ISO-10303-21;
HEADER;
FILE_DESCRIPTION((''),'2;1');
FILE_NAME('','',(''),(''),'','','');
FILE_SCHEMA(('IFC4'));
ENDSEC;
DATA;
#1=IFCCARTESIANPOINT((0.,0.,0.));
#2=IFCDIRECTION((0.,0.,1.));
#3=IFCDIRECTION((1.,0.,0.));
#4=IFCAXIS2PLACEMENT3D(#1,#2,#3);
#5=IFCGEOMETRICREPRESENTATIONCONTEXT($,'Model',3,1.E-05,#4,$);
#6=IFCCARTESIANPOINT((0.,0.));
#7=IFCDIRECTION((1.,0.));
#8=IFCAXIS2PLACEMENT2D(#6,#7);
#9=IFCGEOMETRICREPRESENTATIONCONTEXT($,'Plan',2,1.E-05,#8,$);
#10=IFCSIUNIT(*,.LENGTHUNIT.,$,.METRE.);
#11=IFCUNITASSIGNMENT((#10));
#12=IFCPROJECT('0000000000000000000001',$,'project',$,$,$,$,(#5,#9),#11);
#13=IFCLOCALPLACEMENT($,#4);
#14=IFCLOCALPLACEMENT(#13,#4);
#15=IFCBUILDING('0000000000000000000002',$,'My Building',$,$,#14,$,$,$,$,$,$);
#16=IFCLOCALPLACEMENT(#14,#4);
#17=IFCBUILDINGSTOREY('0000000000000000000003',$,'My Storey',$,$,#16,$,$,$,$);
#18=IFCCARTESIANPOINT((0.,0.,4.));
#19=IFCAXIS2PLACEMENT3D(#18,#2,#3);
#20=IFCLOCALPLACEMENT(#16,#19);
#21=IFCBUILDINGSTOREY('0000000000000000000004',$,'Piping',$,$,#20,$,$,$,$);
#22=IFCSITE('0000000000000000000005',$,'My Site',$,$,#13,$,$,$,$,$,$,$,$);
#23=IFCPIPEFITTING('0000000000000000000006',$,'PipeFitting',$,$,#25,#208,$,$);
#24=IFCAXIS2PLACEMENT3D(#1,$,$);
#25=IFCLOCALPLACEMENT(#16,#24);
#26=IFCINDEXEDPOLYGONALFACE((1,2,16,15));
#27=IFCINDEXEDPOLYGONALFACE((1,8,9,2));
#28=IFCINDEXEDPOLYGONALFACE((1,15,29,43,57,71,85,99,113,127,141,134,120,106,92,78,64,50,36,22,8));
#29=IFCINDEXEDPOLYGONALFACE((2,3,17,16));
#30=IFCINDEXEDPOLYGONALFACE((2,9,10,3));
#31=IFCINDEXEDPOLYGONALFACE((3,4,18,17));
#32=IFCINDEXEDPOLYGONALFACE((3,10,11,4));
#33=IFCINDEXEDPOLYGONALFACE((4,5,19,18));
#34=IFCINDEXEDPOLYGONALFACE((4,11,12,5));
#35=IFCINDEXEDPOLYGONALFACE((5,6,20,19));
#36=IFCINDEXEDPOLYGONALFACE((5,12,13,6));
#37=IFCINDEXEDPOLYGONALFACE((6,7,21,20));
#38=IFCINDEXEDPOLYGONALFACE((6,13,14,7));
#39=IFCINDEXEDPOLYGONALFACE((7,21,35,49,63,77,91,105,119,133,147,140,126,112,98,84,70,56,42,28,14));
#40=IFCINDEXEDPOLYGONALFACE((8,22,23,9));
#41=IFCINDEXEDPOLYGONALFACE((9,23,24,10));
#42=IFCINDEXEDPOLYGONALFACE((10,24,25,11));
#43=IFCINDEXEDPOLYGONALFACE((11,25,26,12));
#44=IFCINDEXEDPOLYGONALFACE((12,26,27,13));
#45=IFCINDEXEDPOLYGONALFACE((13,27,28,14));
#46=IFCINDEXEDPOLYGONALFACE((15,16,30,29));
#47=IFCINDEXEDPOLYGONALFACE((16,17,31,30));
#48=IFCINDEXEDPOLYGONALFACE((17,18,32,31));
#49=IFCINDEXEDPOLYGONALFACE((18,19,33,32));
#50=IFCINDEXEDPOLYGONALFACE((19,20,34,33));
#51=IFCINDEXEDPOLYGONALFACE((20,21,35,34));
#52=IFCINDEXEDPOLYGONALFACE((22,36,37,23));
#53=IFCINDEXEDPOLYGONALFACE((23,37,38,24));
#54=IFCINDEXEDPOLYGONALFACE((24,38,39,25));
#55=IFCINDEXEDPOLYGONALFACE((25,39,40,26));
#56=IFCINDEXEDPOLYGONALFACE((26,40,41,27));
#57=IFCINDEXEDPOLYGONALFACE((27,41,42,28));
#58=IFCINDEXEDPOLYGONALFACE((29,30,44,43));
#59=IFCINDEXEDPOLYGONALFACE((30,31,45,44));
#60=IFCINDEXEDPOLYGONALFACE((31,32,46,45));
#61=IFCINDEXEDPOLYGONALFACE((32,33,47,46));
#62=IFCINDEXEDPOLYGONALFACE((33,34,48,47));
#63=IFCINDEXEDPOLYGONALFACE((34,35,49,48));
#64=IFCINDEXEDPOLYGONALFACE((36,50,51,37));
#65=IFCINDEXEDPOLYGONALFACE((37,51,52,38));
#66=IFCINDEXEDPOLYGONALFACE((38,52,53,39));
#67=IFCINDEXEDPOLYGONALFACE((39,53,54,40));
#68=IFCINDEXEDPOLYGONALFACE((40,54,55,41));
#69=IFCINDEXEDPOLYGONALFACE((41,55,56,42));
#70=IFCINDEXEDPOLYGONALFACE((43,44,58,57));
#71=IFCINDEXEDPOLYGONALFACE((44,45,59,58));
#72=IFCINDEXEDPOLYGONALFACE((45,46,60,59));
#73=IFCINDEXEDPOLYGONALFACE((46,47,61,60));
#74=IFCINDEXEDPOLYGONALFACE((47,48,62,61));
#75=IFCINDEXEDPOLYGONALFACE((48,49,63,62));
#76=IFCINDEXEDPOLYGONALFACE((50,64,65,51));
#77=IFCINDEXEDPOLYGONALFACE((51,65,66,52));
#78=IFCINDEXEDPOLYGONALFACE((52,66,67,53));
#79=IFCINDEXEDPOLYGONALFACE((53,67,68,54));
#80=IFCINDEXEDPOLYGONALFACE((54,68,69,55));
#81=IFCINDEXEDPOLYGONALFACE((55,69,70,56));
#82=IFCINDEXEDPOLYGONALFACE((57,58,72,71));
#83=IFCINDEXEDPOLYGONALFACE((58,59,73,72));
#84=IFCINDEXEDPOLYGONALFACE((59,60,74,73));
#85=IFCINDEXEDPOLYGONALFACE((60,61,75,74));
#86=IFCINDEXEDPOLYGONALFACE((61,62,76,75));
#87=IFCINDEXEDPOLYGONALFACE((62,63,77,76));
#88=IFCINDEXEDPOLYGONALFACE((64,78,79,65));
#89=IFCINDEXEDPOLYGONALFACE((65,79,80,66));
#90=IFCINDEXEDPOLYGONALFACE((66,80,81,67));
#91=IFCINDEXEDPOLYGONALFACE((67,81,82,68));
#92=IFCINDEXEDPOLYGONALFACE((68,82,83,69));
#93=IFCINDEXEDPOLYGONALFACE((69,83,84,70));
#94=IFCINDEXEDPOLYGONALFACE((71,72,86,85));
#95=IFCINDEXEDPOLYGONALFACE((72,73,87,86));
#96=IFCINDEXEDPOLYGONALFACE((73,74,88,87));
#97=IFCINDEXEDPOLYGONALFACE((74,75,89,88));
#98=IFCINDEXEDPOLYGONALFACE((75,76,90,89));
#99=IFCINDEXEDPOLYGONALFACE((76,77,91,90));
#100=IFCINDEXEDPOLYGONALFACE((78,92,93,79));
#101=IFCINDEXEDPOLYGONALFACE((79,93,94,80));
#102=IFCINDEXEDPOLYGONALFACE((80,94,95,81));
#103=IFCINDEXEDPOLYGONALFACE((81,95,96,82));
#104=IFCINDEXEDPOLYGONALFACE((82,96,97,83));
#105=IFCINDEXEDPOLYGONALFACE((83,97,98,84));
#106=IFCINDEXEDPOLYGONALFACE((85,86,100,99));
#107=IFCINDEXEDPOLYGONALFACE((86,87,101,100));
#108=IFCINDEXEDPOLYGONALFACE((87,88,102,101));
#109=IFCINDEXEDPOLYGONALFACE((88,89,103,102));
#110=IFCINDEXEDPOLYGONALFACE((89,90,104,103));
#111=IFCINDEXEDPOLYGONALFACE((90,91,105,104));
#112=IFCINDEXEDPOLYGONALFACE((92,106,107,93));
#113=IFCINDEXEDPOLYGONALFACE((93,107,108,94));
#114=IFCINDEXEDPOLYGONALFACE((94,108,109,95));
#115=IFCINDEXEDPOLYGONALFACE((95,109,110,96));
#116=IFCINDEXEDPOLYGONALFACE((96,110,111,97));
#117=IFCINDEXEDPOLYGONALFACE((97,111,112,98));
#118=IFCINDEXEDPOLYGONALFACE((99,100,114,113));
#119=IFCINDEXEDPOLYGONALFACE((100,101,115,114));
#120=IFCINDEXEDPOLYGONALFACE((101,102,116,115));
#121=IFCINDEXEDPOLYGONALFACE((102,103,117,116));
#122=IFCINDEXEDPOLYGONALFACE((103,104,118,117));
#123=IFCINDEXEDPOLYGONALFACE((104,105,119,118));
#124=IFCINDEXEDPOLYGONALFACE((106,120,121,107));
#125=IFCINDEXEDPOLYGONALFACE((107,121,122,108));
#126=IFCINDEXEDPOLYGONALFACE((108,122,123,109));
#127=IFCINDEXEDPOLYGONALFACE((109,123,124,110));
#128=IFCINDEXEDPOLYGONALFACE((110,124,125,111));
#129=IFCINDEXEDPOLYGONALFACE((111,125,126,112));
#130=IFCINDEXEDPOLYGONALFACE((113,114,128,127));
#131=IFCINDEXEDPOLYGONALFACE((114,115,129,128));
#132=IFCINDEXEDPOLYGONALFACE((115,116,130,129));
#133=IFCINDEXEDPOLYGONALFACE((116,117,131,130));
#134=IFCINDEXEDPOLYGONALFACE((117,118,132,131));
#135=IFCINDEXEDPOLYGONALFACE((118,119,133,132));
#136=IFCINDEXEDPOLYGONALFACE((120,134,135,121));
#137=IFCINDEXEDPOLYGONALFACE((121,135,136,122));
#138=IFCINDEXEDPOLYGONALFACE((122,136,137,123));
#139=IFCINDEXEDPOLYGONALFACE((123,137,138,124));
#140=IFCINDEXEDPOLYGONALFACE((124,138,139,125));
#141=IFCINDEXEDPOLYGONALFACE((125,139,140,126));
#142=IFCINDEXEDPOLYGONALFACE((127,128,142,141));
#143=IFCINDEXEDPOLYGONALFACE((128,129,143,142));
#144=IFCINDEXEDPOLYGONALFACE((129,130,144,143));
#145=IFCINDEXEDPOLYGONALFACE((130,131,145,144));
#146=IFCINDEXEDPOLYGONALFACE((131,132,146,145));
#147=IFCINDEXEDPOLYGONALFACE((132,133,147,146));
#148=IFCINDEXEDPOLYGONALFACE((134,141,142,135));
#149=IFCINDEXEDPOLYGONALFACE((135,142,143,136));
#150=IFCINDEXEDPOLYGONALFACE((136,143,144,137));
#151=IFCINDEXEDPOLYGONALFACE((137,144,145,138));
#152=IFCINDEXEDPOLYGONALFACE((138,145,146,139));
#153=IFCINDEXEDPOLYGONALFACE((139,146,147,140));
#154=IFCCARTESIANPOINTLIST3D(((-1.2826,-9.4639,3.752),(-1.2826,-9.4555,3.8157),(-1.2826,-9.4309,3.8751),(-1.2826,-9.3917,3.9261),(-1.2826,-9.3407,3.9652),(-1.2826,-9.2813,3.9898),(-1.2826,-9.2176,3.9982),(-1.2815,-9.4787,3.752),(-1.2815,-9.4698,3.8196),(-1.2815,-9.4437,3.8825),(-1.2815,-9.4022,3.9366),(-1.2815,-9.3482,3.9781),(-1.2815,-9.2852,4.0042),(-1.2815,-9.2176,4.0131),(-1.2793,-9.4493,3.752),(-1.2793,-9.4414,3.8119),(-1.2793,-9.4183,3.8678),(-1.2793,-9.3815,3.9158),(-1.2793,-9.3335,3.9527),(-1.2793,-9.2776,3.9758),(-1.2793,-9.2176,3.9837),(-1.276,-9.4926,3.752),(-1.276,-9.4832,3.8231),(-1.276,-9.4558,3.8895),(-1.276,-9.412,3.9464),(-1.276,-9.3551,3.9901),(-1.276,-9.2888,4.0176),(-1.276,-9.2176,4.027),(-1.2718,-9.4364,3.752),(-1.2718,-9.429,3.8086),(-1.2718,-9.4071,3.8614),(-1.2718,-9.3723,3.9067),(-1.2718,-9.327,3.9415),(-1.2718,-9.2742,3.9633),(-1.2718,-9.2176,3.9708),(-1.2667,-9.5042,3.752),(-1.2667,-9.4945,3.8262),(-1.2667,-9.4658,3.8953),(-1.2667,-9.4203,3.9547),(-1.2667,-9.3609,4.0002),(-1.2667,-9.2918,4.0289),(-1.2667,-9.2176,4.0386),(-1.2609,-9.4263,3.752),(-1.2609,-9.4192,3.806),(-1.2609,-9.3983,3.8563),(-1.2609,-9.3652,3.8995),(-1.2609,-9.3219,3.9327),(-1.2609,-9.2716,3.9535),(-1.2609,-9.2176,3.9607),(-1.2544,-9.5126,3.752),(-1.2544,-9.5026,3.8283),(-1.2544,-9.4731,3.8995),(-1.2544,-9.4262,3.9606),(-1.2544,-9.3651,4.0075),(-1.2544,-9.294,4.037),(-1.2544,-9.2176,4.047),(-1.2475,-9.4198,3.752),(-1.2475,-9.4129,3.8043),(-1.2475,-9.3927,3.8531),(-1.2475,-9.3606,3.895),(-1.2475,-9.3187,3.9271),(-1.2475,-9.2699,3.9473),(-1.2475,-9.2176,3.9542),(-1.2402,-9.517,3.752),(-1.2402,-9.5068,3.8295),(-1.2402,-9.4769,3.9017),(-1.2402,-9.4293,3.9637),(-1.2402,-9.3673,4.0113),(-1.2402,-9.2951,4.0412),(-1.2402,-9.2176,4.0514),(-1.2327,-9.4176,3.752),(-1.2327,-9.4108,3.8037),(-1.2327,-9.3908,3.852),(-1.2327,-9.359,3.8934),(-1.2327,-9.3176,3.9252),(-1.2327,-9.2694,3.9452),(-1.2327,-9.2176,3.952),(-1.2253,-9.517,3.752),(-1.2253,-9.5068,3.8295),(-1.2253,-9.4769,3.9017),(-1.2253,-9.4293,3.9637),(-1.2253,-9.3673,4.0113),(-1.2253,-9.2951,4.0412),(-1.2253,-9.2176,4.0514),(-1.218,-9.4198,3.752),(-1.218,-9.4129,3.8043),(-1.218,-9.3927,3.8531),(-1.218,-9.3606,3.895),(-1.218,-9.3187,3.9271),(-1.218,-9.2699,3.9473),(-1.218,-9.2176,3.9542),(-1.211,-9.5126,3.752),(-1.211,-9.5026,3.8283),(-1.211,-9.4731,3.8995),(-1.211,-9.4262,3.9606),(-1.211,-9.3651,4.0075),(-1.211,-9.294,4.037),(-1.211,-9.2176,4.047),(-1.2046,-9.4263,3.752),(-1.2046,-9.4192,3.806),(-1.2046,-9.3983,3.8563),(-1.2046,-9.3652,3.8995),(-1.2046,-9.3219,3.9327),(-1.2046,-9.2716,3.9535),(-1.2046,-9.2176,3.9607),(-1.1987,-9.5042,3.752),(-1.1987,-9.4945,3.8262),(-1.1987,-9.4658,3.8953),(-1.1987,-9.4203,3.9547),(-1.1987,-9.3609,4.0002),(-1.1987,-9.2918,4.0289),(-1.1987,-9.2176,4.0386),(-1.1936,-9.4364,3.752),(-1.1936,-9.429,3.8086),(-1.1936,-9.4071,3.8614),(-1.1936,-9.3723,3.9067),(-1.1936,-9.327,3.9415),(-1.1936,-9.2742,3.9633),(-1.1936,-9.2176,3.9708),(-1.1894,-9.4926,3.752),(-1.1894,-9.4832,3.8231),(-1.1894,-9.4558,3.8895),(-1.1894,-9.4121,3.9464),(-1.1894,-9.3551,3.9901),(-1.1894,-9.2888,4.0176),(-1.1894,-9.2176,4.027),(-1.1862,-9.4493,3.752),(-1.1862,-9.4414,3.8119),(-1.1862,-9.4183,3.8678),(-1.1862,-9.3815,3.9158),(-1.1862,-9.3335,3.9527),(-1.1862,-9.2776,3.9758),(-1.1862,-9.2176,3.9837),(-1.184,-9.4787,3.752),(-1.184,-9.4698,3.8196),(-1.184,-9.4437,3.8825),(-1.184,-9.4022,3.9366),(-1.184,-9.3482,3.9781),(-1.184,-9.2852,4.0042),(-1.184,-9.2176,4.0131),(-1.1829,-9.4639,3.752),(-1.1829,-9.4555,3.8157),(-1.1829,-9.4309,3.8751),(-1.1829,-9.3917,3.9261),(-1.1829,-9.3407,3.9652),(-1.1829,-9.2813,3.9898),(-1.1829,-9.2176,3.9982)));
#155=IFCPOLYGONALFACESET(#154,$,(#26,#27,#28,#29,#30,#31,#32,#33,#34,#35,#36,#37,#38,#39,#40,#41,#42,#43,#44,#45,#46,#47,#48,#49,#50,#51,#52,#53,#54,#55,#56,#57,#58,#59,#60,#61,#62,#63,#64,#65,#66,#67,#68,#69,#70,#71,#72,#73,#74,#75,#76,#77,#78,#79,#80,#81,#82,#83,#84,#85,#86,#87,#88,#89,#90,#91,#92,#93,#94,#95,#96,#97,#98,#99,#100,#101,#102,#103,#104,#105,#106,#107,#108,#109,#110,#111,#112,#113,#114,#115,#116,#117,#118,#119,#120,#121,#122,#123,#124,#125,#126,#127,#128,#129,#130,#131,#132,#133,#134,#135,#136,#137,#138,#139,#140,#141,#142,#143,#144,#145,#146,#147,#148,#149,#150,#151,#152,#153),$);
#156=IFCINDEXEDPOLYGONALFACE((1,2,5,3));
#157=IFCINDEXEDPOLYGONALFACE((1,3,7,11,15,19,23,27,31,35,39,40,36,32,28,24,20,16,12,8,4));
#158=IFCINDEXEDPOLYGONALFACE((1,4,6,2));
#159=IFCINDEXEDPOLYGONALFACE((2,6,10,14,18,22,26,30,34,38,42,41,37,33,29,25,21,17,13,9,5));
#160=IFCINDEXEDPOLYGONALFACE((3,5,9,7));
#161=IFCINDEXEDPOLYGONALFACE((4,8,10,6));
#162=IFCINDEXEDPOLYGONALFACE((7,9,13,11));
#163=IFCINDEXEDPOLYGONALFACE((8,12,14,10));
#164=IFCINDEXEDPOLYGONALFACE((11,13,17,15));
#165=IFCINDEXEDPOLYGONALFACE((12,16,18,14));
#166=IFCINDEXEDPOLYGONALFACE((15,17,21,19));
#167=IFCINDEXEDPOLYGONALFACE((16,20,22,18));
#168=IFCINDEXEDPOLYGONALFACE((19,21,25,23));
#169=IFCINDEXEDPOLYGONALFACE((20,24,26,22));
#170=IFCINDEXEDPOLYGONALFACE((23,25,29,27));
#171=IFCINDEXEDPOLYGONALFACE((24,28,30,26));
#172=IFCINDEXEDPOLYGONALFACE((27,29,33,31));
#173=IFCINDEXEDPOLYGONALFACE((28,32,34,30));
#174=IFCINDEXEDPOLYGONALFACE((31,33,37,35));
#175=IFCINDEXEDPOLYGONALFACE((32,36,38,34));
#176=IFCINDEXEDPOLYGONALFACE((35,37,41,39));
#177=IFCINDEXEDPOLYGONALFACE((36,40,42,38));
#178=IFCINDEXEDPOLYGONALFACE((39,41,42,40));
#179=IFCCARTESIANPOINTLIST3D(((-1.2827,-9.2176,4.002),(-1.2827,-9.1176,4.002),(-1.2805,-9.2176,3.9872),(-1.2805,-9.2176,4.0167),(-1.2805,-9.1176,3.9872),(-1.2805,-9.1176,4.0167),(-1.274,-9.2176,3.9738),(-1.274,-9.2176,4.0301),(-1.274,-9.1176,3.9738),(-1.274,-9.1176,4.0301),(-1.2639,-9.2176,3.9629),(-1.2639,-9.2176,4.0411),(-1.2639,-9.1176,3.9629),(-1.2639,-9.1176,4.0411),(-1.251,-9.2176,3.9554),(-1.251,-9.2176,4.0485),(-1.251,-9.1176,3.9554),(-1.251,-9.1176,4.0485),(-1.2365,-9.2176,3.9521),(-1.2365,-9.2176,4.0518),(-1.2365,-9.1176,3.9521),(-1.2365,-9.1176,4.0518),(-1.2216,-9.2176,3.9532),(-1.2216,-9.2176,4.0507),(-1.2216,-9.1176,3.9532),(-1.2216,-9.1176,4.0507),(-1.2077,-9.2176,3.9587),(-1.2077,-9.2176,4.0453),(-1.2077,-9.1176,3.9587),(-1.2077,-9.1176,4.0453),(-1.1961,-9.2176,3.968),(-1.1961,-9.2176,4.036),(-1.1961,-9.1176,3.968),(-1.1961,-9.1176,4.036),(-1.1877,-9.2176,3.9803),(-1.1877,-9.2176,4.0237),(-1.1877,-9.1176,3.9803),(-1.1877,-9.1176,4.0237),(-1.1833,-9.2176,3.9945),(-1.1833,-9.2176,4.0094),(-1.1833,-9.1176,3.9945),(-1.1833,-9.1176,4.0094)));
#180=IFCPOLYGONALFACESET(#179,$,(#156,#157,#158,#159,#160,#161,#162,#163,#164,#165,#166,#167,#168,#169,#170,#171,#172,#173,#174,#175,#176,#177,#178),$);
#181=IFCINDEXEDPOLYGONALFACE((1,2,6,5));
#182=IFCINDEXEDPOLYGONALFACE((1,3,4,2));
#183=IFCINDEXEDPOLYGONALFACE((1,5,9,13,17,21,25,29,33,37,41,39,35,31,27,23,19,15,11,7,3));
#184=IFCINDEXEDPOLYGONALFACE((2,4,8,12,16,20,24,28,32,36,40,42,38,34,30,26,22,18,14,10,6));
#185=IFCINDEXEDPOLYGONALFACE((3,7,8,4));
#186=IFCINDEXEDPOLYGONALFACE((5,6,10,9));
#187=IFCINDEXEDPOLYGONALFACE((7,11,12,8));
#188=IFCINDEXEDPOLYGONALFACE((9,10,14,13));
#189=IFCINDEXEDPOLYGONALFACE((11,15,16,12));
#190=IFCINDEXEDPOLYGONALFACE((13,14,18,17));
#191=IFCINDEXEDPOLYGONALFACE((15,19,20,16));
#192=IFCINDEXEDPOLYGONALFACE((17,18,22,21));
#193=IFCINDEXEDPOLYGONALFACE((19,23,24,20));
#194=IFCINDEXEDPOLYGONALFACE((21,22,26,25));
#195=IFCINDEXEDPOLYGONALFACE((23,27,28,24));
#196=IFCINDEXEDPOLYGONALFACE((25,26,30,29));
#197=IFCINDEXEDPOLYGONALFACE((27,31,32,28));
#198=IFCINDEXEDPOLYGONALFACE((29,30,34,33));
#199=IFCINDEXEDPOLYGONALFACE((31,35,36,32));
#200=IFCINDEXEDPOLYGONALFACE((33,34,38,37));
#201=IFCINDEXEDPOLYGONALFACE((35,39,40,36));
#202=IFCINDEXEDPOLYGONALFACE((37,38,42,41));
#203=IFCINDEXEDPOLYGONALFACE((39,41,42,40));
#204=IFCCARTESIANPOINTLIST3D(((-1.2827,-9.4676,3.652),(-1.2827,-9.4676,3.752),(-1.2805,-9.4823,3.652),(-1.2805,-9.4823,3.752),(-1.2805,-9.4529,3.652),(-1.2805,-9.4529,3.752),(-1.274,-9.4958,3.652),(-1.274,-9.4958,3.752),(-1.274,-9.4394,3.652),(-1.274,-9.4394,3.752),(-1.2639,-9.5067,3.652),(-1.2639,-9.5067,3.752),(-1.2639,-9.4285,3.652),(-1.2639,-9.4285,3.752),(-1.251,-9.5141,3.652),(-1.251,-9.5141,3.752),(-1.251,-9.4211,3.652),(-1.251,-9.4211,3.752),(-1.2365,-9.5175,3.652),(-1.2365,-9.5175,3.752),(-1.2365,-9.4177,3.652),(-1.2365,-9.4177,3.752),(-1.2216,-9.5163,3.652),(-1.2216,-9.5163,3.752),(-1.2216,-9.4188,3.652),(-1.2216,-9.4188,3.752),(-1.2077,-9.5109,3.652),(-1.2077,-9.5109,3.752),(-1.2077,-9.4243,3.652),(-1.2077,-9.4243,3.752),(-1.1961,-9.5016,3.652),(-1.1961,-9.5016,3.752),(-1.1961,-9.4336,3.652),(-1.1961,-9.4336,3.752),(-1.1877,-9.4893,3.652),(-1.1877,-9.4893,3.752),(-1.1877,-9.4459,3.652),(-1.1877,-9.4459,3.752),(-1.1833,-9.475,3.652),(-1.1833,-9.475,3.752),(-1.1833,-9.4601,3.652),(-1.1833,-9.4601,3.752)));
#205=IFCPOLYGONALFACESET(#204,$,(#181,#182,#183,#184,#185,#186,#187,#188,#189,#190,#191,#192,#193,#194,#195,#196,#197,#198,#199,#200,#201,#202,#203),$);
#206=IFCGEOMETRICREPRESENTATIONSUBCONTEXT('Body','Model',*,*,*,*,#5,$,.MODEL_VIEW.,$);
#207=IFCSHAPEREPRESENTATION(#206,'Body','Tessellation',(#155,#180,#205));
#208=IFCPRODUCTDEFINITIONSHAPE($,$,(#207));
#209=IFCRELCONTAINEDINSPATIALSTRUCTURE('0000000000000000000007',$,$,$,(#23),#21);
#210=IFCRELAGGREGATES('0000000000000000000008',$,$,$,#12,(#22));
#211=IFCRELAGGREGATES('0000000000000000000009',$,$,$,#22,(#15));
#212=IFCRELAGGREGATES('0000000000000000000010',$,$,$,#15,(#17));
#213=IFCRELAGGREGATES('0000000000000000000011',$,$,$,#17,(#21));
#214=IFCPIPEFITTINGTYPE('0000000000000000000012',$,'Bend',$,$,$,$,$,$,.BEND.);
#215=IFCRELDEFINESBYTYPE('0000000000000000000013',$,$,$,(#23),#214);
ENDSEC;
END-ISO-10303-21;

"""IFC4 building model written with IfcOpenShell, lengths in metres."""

from ifc_helpers import new_model, entity, si_unit, frame, origin_with_axes, origin_2d_with_axis, place, context, subcontext, project, spatial, line, indexed_curve, circle, outline, extrude, source, transform, mapped, type_object, type_shapes, element, save


model = new_model("IFC4")

# Units and contexts
model_context = context("Model", 3, precision=1e-05, world=origin_with_axes())
plan_context = context("Plan", 2, precision=1e-05, world=origin_2d_with_axis())
body_context = subcontext(model_context, "Body", "Model", "MODEL_VIEW")
ifc_project = project(units=[si_unit("LENGTHUNIT", "METRE")], contexts=[model_context, plan_context])

# Site, building, storeys
site_placement = place(None, origin_with_axes())
site = spatial("IfcSite", under=ifc_project, at=site_placement, Name="My Site")
building_placement = place(site_placement, origin_with_axes())
building = spatial("IfcBuilding", under=site, at=building_placement, Name="My Building")
storey_1_placement = place(building_placement, origin_with_axes())
storey_1 = spatial("IfcBuildingStorey", under=building, at=storey_1_placement, Name="My Storey")
storey_2_placement = place(storey_1_placement, frame((0.0, 0.0, 4.0), z_axis=(0.0, 0.0, 1.0), x_axis=(1.0, 0.0, 0.0)))
storey_2 = spatial("IfcBuildingStorey", under=storey_1, at=storey_2_placement, Name="Piping")

# Shared definitions
pipe_fitting_type_1 = type_object("IfcPipeFittingType", Name="Bend", PredefinedType="BEND")
shared_shape = source(origin_with_axes(), body_context, "Body", "SolidModel", [
    entity("IfcSweptDiskSolid", entity("IfcIndexedPolyCurve", entity("IfcCartesianPointList3D", [[0.0, 0.0, -0.1], [0.0, -0.0732, -0.2768], [0.0, -0.25, -0.35]]), [entity("IfcArcIndex", [1, 2, 3])]), 0.05),
    extrude(circle(Radius=0.05), origin_with_axes(), (0.0, 0.0, -1.0), 0.1),
    extrude(circle(Radius=0.05), frame((0.0, -0.25, -0.35), z_axis=(0.0, -1.0, 0.0), x_axis=(1.0, 0.0, 0.0)), (0.0, 0.0, 1.0), 0.1),
])
type_shapes(pipe_fitting_type_1, [shared_shape])

# Pipe fitting, opening
pipe_fitting_1_placement = place(storey_2_placement, frame((-1.2327, -9.1176, 0.002), z_axis=(0.0, 1.0, 0.000001), x_axis=(-1.0, 0.0, 0.0)))
pipe_fitting_1 = element("IfcPipeFitting", 1, at=pipe_fitting_1_placement, inside=storey_2, type_object=pipe_fitting_type_1, Name="PipeFitting", context=body_context, shape_type="MappedRepresentation", body=[
    mapped(shared_shape, transform((0.0, 0.0, 0.0), x_axis=(1.0, 0.0, 0.0), y_axis=(0.0, 1.0, 0.0), z_axis=(0.0, 0.0, 1.0), scale=1.0)),
])
opening_1_placement = place(pipe_fitting_1_placement, frame((-1.2327, -4.002, 9.1176), z_axis=(0.0, 1.0, 0.000001), x_axis=(-1.0, 0.0, 0.0)))
element("IfcOpeningElement", 2, at=opening_1_placement, cuts=pipe_fitting_1, PredefinedType="OPENING", context=body_context, shape_type="SweptSolid", body=[
    extrude(outline(indexed_curve([(0.0, 0.0), (0.5, 0.0), (0.5, 0.5), (0.0, 0.5)], segments=[line(1, 2, 3, 4, 1)])), origin_with_axes(), (0.0, 0.0, 1.0), 0.5),
])

save(model, "model.ifc")
